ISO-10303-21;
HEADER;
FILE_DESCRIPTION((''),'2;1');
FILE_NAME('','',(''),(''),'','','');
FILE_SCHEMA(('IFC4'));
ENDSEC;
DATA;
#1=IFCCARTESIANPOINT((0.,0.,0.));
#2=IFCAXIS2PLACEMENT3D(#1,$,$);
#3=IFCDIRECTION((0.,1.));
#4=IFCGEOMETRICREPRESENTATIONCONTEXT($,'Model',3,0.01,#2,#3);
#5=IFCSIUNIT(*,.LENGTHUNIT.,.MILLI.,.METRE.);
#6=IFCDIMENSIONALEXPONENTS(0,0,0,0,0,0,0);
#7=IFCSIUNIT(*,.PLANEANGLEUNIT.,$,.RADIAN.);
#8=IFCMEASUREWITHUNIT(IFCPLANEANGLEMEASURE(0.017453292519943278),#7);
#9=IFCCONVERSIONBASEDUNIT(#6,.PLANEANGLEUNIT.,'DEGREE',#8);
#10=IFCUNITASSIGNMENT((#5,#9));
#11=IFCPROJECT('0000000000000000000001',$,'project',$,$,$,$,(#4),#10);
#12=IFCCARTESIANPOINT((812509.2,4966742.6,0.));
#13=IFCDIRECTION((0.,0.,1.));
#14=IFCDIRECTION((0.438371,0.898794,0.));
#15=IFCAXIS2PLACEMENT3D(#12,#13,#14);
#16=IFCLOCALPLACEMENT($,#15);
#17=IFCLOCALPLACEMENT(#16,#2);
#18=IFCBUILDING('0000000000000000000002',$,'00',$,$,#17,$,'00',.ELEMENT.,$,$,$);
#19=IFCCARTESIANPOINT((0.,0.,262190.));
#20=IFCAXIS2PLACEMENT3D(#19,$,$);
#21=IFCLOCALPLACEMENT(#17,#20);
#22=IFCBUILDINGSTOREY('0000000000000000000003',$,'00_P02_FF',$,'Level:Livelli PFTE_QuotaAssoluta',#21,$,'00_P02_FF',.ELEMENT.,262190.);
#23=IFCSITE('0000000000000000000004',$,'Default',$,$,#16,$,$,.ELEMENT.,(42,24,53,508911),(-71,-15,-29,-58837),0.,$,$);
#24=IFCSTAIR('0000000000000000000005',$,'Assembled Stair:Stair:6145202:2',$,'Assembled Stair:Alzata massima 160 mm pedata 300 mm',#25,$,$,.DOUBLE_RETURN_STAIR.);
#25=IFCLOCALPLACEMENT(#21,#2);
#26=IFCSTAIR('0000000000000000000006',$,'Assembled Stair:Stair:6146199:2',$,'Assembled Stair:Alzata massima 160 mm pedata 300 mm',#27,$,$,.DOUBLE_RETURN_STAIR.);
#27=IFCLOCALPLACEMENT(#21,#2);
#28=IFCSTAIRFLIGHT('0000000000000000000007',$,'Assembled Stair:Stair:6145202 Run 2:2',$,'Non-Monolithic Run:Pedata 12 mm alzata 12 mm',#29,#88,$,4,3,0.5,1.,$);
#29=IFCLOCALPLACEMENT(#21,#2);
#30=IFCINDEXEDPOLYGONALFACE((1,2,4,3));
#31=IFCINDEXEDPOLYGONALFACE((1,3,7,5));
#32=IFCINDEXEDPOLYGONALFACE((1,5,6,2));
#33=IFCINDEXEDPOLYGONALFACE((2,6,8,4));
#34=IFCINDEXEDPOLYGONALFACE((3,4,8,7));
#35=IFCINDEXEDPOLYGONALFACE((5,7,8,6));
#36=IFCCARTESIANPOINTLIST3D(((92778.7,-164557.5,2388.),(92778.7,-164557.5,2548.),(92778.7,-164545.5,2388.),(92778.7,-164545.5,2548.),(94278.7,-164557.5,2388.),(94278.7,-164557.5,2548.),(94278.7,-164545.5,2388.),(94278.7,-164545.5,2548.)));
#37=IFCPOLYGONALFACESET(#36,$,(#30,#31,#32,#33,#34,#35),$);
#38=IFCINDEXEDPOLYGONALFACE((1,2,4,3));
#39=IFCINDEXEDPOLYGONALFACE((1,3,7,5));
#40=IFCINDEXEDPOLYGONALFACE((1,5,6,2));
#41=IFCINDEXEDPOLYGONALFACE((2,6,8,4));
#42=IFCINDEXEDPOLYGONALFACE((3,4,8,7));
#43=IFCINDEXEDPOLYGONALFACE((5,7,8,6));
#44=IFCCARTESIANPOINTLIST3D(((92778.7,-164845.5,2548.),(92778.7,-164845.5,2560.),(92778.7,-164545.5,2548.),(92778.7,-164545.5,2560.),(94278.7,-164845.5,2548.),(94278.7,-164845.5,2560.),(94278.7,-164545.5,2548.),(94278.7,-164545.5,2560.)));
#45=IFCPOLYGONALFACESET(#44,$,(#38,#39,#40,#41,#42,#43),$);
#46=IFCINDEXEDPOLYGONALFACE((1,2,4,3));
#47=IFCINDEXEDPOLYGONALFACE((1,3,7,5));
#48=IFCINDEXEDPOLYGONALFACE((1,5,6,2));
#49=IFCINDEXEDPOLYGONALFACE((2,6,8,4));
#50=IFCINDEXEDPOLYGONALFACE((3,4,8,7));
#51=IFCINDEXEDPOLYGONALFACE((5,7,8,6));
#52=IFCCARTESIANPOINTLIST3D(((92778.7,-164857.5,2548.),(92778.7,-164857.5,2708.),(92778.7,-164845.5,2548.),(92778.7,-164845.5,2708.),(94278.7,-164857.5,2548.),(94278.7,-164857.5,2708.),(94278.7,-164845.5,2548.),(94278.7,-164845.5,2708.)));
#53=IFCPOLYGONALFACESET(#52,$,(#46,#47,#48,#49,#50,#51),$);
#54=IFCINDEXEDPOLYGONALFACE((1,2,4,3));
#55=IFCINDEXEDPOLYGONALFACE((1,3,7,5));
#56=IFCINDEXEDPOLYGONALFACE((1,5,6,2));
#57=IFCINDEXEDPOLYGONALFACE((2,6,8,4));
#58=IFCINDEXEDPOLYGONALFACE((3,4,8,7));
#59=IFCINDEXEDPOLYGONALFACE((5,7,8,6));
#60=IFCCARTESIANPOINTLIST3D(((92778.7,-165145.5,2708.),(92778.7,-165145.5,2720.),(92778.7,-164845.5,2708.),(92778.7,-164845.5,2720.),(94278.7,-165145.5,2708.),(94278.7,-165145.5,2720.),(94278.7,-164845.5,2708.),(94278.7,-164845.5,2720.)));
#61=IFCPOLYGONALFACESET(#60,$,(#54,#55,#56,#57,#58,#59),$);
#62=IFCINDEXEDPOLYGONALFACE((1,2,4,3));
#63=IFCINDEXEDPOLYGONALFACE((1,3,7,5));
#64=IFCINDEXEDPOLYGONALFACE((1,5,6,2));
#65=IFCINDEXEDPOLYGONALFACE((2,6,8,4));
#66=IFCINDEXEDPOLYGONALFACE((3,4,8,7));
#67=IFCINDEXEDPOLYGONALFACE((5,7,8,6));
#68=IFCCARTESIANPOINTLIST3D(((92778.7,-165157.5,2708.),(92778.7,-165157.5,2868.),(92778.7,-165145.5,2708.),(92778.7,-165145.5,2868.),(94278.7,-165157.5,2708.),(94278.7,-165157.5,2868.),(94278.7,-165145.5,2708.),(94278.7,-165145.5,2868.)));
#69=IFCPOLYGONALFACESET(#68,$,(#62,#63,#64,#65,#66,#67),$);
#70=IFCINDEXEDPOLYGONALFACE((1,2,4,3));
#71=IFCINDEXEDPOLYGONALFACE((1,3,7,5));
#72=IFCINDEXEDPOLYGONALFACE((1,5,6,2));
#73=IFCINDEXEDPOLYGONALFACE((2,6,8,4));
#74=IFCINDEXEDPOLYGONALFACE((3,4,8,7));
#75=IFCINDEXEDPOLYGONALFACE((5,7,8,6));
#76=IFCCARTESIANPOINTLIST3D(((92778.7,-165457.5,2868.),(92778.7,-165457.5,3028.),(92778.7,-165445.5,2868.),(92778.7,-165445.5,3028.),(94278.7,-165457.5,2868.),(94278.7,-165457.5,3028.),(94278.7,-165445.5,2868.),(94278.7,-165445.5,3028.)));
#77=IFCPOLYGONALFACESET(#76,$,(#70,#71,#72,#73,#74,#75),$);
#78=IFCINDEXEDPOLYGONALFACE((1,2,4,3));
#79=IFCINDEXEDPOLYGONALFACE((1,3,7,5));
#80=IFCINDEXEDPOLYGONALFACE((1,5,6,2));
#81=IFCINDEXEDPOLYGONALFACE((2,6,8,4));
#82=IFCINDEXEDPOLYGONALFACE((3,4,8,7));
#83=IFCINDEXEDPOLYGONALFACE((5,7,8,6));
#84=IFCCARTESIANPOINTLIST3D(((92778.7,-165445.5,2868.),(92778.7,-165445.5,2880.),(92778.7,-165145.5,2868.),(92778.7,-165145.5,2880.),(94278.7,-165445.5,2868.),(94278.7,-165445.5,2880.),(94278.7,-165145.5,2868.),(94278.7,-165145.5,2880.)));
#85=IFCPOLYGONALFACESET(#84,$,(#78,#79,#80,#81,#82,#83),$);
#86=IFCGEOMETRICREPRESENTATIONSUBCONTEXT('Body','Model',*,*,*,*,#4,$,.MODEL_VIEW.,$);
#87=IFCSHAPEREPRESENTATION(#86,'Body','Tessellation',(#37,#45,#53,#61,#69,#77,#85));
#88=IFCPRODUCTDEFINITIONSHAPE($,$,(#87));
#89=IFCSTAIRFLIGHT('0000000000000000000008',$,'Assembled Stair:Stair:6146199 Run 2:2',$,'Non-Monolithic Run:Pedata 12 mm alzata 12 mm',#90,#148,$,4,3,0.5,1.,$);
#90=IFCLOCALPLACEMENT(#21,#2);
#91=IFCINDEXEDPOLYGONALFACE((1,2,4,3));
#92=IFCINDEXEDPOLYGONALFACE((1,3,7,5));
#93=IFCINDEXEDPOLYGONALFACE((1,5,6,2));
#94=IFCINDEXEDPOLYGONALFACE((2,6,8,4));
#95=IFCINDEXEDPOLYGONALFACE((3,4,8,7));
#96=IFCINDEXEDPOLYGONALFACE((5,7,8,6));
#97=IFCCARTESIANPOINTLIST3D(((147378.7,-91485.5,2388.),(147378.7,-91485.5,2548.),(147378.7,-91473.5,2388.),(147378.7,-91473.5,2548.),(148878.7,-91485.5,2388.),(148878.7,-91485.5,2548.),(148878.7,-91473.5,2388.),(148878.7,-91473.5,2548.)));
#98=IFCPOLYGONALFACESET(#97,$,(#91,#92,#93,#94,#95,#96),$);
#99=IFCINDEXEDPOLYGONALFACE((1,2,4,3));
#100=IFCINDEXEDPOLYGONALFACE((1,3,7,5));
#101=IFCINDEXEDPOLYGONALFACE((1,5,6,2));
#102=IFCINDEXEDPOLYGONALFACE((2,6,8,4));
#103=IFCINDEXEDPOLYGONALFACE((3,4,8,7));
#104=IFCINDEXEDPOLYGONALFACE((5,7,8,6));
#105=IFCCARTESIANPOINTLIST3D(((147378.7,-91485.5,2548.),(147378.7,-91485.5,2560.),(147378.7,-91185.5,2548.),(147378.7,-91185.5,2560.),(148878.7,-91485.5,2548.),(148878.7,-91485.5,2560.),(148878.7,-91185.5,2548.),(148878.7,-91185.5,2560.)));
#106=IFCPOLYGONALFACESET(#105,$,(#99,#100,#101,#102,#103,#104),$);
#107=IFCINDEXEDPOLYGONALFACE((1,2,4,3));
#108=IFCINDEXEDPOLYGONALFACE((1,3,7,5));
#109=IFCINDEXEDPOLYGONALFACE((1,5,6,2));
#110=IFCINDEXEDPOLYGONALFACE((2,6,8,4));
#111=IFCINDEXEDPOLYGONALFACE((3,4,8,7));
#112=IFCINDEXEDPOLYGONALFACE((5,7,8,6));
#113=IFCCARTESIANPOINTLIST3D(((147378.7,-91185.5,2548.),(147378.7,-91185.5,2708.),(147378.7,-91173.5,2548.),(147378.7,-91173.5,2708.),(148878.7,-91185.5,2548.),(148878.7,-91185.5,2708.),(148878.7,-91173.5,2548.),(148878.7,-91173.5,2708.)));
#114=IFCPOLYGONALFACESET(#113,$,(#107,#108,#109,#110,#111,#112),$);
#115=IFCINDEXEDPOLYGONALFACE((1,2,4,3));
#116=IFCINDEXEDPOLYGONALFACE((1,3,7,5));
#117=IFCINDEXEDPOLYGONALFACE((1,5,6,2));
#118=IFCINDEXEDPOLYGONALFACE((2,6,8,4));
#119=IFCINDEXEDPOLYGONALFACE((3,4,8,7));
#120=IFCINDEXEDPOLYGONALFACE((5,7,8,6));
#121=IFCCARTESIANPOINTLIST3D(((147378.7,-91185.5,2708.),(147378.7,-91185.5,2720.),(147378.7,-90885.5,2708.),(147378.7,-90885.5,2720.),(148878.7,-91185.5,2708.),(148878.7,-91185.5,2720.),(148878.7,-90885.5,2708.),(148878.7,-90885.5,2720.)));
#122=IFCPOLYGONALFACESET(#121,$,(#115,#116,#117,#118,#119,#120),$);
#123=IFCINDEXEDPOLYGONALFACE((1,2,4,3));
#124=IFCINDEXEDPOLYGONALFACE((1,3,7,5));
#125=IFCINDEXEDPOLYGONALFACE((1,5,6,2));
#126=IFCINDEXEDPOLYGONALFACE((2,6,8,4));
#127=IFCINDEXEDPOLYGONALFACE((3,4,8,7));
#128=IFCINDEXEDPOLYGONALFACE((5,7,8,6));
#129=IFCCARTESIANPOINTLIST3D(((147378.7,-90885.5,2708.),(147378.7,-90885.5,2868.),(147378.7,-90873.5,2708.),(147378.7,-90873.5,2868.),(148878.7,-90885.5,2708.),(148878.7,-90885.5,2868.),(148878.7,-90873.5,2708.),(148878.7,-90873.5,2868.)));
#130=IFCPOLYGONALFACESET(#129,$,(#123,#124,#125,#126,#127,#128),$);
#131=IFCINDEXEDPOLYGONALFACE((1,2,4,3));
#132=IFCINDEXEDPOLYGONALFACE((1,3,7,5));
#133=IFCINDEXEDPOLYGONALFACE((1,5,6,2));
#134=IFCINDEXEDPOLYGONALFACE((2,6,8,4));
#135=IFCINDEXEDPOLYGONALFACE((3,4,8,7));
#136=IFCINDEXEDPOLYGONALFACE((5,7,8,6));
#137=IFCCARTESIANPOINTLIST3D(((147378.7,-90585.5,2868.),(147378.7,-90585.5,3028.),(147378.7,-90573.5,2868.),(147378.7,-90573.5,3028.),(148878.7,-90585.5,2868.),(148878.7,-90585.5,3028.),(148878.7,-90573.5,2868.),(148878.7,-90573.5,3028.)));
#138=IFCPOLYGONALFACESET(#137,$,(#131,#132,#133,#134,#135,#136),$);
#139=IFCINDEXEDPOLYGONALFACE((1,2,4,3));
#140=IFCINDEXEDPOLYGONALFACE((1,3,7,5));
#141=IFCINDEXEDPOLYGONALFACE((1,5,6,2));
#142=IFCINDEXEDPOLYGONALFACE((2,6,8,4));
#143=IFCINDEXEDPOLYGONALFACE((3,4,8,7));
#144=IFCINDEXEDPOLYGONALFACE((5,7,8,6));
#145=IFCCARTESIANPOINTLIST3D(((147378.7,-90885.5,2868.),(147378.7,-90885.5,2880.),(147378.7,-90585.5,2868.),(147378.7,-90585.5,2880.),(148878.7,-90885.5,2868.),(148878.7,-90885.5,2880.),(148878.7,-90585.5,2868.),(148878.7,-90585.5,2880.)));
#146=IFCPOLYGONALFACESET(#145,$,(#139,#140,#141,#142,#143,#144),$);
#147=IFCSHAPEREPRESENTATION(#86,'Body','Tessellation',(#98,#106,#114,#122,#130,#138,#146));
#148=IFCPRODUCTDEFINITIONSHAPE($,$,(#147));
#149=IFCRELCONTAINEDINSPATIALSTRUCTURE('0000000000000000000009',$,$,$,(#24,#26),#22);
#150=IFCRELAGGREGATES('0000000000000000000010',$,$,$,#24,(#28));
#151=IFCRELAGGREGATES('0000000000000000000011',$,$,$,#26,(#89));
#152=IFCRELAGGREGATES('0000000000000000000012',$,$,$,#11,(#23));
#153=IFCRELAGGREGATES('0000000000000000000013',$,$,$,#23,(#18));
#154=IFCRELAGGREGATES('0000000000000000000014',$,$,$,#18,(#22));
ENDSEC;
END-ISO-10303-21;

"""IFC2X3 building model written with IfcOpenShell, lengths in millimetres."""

from ifc_helpers import new_model, entity, si_unit, converted_unit, direction, frame, frame_2d, origin, origin_2d_with_axis, place, context, subcontext, project, spatial, rectangle, extrude, element, aggregate, save


model = new_model("IFC2X3")

# Units and contexts
model_context = context("Model", 3, precision=0.01, world=origin(), true_north=direction((0.0, 1.0)))
body_context = subcontext(model_context, "Body", "Model", "MODEL_VIEW")
ifc_project = project(units=[si_unit("LENGTHUNIT", "METRE", prefix="MILLI"), converted_unit("PLANEANGLEUNIT", "DEGREE", entity("IfcPlaneAngleMeasure", 0.017453292519943278), si_unit("PLANEANGLEUNIT", "RADIAN"), dimensions=[0, 0, 0, 0, 0, 0, 0])], contexts=[model_context])

# Site, building, storey
site_placement = place(None, frame((812509.2, 4966742.6, 0.0), z_axis=(0.0, 0.0, 1.0), x_axis=(0.438371, 0.898794, 0.0)))
site = spatial("IfcSite", under=ifc_project, at=site_placement, Name="Default", CompositionType="ELEMENT", RefLatitude=(42, 24, 53, 508911), RefLongitude=(-71, -15, -29, -58837), RefElevation=0.0)
building_placement = place(site_placement, origin())
building = spatial("IfcBuilding", under=site, at=building_placement, Name="00", LongName="00", CompositionType="ELEMENT")
storey_placement = place(building_placement, frame((0.0, 0.0, 262190.0)))
storey = spatial("IfcBuildingStorey", under=building, at=storey_placement, Name="00_P02_FF", ObjectType="Level:Livelli PFTE_QuotaAssoluta", LongName="00_P02_FF", CompositionType="ELEMENT", Elevation=262190.0)

# Stairs
stair_1_placement = place(storey_placement, origin())
stair_1 = element("IfcStair", 1, at=stair_1_placement, inside=storey, Name="Assembled Stair:Stair:6145202:2", ObjectType="Assembled Stair:Alzata massima 160 mm pedata 300 mm", ShapeType="DOUBLE_RETURN_STAIR")
stair_2_placement = place(storey_placement, origin())
stair_2 = element("IfcStair", 2, at=stair_2_placement, inside=storey, Name="Assembled Stair:Stair:6146199:2", ObjectType="Assembled Stair:Alzata massima 160 mm pedata 300 mm", ShapeType="DOUBLE_RETURN_STAIR")

# Stair flights
stair_flight_1_placement = place(stair_1_placement, origin())
stair_flight_1 = element("IfcStairFlight", 3, at=stair_flight_1_placement, Name="Assembled Stair:Stair:6145202 Run 2:2", ObjectType="Non-Monolithic Run:Pedata 12 mm alzata 12 mm", NumberOfRiser=4, NumberOfTreads=3, RiserHeight=0.5, TreadLength=1.0, context=body_context, shape_type="SweptSolid", body=[
    extrude(rectangle(XDim=1500.0, YDim=12.0, at=origin_2d_with_axis()), frame((93528.7, -164551.5, 2388.0)), (0.0, 0.0, 1.0), 160.0),
    extrude(rectangle(XDim=300.0, YDim=1500.0, at=origin_2d_with_axis()), frame((93528.7, -164695.5, 2548.0), z_axis=(0.0, 0.0, 1.0), x_axis=(0.0, 1.0, 0.0)), (0.0, 0.0, 1.0), 12.0),
    extrude(rectangle(XDim=1500.0, YDim=12.0, at=origin_2d_with_axis()), frame((93528.7, -164851.5, 2548.0)), (0.0, 0.0, 1.0), 160.0),
    extrude(rectangle(XDim=300.0, YDim=1500.0, at=frame_2d((0.0, 0.0), x_axis=(1.0, 0.0))), frame((93528.7, -164995.5, 2708.0), z_axis=(0.0, 0.0, 1.0), x_axis=(0.0, 1.0, 0.0)), (0.0, 0.0, 1.0), 12.0),
    extrude(rectangle(XDim=1500.0, YDim=12.0, at=origin_2d_with_axis()), frame((93528.7, -165151.5, 2708.0)), (0.0, 0.0, 1.0), 160.0),
    extrude(rectangle(XDim=1500.0, YDim=12.0, at=origin_2d_with_axis()), frame((93528.7, -165451.5, 2868.0)), (0.0, 0.0, 1.0), 160.0),
    extrude(rectangle(XDim=300.0, YDim=1500.0, at=frame_2d((0.0, 0.0), x_axis=(1.0, 0.0))), frame((93528.7, -165295.5, 2868.0), z_axis=(0.0, 0.0, 1.0), x_axis=(0.0, 1.0, 0.0)), (0.0, 0.0, 1.0), 12.0),
])
aggregate(stair_1, [stair_flight_1])
stair_flight_2_placement = place(stair_2_placement, origin())
stair_flight_2 = element("IfcStairFlight", 4, at=stair_flight_2_placement, Name="Assembled Stair:Stair:6146199 Run 2:2", ObjectType="Non-Monolithic Run:Pedata 12 mm alzata 12 mm", NumberOfRiser=4, NumberOfTreads=3, RiserHeight=0.5, TreadLength=1.0, context=body_context, shape_type="SweptSolid", body=[
    extrude(rectangle(XDim=1500.0, YDim=12.0, at=origin_2d_with_axis()), frame((148128.7, -91479.5, 2388.0), z_axis=(0.0, 0.0, 1.0), x_axis=(-1.0, 0.0, 0.0)), (0.0, 0.0, 1.0), 160.0),
    extrude(rectangle(XDim=300.0, YDim=1500.0, at=frame_2d((0.0, 0.0), x_axis=(1.0, 0.0))), frame((148128.7, -91335.5, 2548.0), z_axis=(0.0, 0.0, 1.0), x_axis=(0.0, -1.0, 0.0)), (0.0, 0.0, 1.0), 12.0),
    extrude(rectangle(XDim=1500.0, YDim=12.0, at=frame_2d((0.0, 0.0), x_axis=(1.0, 0.0))), frame((148128.7, -91179.5, 2548.0), z_axis=(0.0, 0.0, 1.0), x_axis=(-1.0, 0.0, 0.0)), (0.0, 0.0, 1.0), 160.0),
    extrude(rectangle(XDim=300.0, YDim=1500.0, at=origin_2d_with_axis()), frame((148128.7, -91035.5, 2708.0), z_axis=(0.0, 0.0, 1.0), x_axis=(0.0, -1.0, 0.0)), (0.0, 0.0, 1.0), 12.0),
    extrude(rectangle(XDim=1500.0, YDim=12.0, at=frame_2d((0.0, 0.0), x_axis=(1.0, 0.0))), frame((148128.7, -90879.5, 2708.0), z_axis=(0.0, 0.0, 1.0), x_axis=(-1.0, 0.0, 0.0)), (0.0, 0.0, 1.0), 160.0),
    extrude(rectangle(XDim=1500.0, YDim=12.0, at=origin_2d_with_axis()), frame((148128.7, -90579.5, 2868.0), z_axis=(0.0, 0.0, 1.0), x_axis=(-1.0, 0.0, 0.0)), (0.0, 0.0, 1.0), 160.0),
    extrude(rectangle(XDim=300.0, YDim=1500.0, at=origin_2d_with_axis()), frame((148128.7, -90735.5, 2868.0), z_axis=(0.0, 0.0, 1.0), x_axis=(0.0, -1.0, 0.0)), (0.0, 0.0, 1.0), 12.0),
])
aggregate(stair_2, [stair_flight_2])

save(model, "model.ifc")
